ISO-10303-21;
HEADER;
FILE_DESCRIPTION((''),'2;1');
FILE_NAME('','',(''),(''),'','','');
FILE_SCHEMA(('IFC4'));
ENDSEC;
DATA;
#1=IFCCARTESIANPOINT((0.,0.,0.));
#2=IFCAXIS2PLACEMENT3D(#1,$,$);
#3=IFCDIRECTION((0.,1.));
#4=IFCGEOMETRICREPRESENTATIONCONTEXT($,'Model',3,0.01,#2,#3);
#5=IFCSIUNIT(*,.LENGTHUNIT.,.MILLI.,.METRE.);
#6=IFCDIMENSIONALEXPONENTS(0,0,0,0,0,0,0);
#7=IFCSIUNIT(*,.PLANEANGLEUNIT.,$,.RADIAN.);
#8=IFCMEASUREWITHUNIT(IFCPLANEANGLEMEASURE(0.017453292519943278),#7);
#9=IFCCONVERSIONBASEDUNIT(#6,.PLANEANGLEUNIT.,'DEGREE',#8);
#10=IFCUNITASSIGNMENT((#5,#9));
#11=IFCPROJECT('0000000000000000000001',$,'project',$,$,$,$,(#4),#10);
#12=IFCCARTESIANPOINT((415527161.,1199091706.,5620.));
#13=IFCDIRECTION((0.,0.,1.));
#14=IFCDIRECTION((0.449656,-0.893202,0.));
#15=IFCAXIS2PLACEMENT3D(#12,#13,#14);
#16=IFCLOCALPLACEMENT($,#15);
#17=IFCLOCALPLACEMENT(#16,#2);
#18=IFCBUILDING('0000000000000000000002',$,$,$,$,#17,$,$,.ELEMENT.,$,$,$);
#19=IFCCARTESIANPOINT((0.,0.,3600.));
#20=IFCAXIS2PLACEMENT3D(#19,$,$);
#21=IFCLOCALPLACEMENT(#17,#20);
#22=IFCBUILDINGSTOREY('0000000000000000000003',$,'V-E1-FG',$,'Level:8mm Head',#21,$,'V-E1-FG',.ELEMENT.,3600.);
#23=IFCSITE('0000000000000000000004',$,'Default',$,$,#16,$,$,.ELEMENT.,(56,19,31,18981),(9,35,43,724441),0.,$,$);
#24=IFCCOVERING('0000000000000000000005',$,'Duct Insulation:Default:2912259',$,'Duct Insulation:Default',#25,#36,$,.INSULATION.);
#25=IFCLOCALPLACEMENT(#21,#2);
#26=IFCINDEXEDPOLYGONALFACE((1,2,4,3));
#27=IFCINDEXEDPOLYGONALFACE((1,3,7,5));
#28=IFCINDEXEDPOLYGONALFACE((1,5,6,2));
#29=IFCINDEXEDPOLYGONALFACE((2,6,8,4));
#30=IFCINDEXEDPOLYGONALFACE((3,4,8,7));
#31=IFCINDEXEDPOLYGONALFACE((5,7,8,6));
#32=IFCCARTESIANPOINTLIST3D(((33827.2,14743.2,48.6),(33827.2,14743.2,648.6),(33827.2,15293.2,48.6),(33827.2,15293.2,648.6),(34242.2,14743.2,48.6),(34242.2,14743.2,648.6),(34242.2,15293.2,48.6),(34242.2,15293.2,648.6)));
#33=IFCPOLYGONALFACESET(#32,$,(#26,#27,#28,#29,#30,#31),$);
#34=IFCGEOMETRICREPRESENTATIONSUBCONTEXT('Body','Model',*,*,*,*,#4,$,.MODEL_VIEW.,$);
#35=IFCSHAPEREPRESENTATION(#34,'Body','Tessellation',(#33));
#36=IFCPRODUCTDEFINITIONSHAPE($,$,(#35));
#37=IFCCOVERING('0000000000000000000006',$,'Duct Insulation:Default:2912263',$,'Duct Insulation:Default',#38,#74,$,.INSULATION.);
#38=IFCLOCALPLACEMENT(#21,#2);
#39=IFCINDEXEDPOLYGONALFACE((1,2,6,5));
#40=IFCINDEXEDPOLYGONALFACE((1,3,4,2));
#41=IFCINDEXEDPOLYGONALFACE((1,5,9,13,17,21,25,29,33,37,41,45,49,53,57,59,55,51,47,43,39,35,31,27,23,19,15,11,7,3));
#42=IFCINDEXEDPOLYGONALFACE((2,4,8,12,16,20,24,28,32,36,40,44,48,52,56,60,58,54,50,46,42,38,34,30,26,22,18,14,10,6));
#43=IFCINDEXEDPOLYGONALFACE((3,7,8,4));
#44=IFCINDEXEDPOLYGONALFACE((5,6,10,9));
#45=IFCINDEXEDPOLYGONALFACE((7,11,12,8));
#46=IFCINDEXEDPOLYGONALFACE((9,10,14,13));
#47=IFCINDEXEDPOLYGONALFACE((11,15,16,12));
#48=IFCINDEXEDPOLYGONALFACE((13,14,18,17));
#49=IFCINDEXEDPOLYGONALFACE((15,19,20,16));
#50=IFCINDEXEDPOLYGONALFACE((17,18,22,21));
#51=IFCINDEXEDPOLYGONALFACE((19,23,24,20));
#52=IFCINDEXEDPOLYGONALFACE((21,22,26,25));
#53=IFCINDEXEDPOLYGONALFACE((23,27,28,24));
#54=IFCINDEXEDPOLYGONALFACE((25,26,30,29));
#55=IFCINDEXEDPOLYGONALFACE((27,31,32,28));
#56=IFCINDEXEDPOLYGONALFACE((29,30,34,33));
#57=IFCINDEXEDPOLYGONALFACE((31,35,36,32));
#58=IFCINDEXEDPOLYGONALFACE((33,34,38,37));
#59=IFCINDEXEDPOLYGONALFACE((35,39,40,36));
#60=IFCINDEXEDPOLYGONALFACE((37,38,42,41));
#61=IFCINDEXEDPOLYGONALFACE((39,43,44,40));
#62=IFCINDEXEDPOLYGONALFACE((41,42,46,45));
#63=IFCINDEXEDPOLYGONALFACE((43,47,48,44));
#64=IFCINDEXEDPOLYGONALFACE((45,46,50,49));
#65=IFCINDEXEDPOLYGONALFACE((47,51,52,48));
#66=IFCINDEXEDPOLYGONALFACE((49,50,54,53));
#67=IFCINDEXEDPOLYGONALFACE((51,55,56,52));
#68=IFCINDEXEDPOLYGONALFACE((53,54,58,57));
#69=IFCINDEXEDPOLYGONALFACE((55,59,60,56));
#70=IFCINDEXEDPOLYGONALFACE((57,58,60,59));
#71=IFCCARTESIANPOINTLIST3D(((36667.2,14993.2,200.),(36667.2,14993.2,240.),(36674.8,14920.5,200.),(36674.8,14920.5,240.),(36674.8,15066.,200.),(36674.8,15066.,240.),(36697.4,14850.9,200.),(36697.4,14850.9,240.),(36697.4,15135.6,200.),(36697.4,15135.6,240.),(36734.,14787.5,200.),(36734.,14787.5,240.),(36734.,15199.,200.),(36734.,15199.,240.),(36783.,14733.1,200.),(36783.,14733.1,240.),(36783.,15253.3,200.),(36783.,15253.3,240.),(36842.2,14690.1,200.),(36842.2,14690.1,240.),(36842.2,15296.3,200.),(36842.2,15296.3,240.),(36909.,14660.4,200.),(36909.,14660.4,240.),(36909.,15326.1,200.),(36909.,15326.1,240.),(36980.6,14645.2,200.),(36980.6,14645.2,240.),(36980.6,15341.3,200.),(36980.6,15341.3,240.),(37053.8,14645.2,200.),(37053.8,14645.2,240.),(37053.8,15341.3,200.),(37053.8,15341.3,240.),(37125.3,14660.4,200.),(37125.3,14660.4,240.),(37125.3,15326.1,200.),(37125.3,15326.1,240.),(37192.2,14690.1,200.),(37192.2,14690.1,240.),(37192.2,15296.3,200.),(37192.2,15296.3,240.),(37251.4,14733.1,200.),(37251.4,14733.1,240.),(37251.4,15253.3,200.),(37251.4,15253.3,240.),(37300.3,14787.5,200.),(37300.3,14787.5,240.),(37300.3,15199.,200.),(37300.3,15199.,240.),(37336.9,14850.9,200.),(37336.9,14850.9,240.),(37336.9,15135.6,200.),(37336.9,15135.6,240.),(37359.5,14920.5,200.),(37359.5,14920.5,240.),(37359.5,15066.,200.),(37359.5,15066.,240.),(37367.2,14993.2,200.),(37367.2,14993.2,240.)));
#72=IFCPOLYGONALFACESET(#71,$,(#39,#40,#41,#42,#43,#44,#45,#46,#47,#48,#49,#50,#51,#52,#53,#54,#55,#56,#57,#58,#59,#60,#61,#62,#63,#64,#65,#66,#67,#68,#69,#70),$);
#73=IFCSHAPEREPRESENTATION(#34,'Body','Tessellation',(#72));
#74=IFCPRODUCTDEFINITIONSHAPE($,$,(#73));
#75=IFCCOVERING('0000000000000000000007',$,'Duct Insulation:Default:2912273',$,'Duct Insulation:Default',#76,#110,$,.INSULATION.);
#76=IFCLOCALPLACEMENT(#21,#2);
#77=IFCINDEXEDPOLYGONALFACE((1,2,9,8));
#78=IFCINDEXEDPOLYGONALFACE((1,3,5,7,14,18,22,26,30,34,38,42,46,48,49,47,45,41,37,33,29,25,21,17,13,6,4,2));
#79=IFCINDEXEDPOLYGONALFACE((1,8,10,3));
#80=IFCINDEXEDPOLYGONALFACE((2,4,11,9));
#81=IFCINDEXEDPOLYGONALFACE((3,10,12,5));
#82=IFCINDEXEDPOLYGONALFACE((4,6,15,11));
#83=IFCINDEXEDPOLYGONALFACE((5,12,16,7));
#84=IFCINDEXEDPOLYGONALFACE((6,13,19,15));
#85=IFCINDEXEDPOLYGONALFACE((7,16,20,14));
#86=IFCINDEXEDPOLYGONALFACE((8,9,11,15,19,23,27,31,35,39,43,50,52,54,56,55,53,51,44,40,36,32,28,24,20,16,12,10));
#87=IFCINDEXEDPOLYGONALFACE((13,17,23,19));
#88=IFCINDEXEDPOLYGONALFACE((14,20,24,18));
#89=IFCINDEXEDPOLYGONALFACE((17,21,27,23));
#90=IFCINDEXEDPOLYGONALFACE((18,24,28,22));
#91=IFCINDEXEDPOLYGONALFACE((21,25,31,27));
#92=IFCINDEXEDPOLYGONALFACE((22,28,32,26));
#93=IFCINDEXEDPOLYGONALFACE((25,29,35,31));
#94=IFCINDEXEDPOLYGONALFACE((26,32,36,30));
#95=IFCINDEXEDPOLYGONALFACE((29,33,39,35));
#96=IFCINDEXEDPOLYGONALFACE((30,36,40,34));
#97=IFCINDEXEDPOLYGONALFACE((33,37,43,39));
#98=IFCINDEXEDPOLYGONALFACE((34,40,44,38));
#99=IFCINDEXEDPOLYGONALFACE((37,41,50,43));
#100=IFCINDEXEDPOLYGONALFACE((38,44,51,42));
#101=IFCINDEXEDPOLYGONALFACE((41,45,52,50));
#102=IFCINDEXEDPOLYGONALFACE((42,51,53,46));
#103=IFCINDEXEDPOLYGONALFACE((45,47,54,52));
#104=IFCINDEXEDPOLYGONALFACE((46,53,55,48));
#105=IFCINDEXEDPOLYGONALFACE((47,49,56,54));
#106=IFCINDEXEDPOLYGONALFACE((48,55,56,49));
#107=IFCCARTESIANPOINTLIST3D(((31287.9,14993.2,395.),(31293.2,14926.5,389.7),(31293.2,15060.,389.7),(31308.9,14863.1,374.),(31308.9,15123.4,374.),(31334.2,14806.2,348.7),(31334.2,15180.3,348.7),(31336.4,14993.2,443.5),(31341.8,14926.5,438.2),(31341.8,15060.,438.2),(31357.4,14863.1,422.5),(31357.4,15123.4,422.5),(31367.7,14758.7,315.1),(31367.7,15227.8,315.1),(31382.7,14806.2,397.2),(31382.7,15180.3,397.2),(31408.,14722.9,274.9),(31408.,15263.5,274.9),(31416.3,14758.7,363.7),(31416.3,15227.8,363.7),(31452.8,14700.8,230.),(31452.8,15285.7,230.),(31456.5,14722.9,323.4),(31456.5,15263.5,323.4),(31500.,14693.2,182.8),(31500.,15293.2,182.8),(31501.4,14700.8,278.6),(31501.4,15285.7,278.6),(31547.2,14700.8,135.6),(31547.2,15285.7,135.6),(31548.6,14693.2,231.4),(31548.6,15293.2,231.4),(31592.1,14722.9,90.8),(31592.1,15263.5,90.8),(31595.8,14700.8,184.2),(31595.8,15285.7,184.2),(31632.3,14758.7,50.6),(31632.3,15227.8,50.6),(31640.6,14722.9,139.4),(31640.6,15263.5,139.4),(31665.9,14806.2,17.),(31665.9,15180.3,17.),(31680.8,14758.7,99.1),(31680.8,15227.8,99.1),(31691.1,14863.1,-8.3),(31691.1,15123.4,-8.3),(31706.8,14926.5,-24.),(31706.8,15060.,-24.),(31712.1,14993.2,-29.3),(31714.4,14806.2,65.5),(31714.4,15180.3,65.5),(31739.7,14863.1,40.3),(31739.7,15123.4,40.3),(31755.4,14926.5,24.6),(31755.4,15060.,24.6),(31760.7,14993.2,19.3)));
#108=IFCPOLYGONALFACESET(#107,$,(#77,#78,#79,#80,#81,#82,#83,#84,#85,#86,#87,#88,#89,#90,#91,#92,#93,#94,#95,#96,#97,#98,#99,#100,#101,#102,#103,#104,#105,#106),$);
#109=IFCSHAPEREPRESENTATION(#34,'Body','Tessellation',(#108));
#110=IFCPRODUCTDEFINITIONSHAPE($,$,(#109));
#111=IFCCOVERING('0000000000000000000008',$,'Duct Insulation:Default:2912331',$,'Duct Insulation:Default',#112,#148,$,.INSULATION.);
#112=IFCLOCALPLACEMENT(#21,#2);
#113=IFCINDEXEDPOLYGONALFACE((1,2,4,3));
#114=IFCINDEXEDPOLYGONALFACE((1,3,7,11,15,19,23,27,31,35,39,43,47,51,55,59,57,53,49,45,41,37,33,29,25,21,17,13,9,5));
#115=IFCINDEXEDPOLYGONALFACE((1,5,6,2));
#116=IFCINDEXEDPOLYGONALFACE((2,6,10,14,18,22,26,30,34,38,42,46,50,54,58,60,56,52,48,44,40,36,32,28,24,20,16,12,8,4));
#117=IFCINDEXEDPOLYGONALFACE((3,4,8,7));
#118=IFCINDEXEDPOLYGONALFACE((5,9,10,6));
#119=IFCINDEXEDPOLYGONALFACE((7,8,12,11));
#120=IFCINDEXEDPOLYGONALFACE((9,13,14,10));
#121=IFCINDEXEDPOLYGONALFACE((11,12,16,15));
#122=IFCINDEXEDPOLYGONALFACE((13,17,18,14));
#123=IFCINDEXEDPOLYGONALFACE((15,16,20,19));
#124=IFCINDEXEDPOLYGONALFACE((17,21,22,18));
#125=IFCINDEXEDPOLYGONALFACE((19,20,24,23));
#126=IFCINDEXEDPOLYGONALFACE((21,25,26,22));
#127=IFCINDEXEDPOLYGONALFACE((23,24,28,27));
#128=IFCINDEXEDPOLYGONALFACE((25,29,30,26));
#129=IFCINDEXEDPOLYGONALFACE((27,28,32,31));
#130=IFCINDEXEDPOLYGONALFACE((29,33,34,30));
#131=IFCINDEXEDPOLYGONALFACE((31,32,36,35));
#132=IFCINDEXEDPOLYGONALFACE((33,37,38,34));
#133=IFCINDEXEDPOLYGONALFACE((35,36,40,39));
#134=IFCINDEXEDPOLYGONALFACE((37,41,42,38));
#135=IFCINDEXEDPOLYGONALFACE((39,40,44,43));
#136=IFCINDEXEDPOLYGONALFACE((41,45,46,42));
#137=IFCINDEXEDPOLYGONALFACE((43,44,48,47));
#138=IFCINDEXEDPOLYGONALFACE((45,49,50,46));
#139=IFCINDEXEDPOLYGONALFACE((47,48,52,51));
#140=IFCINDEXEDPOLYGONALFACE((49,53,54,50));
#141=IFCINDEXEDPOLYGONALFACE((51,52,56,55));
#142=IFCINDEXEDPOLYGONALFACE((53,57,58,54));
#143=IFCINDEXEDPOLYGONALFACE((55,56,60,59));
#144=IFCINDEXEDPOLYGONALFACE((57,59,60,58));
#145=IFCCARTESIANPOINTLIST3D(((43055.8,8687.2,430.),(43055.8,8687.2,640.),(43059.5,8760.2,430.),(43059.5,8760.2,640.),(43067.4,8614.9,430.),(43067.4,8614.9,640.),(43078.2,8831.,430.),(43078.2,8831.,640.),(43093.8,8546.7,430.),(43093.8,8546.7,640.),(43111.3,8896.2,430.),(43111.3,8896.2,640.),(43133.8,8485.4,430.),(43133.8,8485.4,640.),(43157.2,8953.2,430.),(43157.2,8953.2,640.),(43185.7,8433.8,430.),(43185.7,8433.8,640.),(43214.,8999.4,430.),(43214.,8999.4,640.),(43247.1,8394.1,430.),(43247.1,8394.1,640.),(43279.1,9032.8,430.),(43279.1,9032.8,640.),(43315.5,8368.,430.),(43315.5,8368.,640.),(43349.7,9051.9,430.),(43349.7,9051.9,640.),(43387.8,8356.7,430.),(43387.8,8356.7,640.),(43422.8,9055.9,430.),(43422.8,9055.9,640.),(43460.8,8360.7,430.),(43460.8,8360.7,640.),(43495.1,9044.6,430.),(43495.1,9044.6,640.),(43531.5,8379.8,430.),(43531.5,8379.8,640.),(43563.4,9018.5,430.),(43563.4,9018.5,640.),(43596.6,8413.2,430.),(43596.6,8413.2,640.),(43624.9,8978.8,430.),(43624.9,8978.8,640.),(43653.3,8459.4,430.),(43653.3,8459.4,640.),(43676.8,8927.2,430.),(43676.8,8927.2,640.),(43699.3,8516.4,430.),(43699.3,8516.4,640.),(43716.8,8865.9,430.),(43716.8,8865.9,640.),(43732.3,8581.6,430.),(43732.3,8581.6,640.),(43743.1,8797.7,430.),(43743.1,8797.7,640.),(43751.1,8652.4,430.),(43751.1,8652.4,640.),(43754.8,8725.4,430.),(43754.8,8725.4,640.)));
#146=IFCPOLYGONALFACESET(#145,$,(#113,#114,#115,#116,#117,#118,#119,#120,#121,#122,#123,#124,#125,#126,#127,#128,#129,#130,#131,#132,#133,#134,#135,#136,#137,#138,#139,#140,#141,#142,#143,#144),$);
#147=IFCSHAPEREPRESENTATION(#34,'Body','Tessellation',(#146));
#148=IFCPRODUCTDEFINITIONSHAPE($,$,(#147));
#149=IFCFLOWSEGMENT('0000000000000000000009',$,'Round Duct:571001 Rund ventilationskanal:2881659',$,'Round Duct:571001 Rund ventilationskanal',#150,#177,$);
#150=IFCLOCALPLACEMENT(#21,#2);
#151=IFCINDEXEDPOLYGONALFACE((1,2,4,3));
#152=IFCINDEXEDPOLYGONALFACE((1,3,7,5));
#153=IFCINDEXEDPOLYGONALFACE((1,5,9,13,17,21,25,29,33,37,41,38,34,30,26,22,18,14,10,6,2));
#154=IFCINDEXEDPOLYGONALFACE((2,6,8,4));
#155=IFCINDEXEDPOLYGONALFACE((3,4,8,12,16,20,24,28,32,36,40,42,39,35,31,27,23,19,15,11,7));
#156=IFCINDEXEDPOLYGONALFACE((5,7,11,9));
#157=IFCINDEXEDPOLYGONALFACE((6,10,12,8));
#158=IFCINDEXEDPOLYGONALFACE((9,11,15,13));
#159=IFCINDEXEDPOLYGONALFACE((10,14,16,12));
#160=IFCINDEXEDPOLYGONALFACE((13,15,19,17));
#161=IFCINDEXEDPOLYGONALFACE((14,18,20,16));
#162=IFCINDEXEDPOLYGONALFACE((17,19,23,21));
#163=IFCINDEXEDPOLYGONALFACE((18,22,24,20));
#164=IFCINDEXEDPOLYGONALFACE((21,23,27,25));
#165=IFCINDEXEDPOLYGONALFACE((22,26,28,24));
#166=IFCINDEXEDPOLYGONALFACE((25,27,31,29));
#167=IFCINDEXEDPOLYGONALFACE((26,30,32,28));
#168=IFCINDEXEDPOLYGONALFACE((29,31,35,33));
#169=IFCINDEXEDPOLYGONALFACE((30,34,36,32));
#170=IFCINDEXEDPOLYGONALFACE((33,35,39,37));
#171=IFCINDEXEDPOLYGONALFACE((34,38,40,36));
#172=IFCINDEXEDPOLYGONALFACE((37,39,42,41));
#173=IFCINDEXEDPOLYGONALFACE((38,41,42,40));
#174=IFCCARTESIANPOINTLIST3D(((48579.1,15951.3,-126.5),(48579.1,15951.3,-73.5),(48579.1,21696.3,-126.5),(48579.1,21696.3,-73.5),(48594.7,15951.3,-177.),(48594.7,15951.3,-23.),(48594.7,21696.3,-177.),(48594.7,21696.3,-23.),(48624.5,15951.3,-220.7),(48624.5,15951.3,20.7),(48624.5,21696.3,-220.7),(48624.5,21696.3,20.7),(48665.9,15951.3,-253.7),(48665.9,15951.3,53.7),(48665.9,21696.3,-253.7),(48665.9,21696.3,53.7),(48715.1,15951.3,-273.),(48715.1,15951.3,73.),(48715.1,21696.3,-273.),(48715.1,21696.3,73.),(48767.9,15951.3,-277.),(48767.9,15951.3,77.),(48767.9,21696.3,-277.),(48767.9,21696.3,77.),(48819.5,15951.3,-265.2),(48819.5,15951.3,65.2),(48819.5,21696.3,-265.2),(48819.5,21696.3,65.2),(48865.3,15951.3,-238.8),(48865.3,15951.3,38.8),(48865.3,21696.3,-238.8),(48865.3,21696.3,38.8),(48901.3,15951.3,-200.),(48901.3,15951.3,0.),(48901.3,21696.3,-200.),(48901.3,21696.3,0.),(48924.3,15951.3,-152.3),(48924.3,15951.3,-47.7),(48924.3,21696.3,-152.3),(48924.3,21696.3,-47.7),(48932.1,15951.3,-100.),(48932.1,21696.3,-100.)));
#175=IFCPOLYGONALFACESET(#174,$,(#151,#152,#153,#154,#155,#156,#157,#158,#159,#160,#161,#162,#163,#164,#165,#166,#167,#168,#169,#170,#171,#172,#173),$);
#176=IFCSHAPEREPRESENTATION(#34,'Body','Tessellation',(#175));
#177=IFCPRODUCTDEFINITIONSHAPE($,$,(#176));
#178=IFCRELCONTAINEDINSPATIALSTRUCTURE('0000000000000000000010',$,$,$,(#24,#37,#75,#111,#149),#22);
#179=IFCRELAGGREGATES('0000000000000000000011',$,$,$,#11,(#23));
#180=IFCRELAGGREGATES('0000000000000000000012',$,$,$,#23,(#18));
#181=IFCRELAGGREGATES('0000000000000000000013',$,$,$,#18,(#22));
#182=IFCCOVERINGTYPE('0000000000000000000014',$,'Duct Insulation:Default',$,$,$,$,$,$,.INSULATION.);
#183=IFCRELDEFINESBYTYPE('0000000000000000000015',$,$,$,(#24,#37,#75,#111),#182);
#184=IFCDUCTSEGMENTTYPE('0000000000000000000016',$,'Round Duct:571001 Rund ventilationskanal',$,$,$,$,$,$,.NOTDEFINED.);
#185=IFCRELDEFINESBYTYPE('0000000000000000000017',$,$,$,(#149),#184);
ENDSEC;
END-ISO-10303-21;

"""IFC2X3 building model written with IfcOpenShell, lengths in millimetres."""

from ifc_helpers import new_model, entity, si_unit, converted_unit, direction, frame, frame_2d, origin, place, context, subcontext, project, spatial, rectangle, circle, extrude, type_object, element, save


model = new_model("IFC2X3")

# Units and contexts
model_context = context("Model", 3, precision=0.01, world=origin(), true_north=direction((0.0, 1.0)))
body_context = subcontext(model_context, "Body", "Model", "MODEL_VIEW")
ifc_project = project(units=[si_unit("LENGTHUNIT", "METRE", prefix="MILLI"), converted_unit("PLANEANGLEUNIT", "DEGREE", entity("IfcPlaneAngleMeasure", 0.017453292519943278), si_unit("PLANEANGLEUNIT", "RADIAN"), dimensions=[0, 0, 0, 0, 0, 0, 0])], contexts=[model_context])

# Site, building, storey
site_placement = place(None, frame((415527161.0, 1199091706.0, 5620.0), z_axis=(0.0, 0.0, 1.0), x_axis=(0.449656, -0.893202, 0.0)))
site = spatial("IfcSite", under=ifc_project, at=site_placement, Name="Default", CompositionType="ELEMENT", RefLatitude=(56, 19, 31, 18981), RefLongitude=(9, 35, 43, 724441), RefElevation=0.0)
building_placement = place(site_placement, origin())
building = spatial("IfcBuilding", under=site, at=building_placement, CompositionType="ELEMENT")
storey_placement = place(building_placement, frame((0.0, 0.0, 3600.0)))
storey = spatial("IfcBuildingStorey", under=building, at=storey_placement, Name="V-E1-FG", ObjectType="Level:8mm Head", LongName="V-E1-FG", CompositionType="ELEMENT", Elevation=3600.0)

# Coverings
covering_type = type_object("IfcCoveringType", Name="Duct Insulation:Default", PredefinedType="INSULATION")
covering_1_placement = place(storey_placement, origin())
element("IfcCovering", 1, at=covering_1_placement, inside=storey, type_object=covering_type, Name="Duct Insulation:Default:2912259", ObjectType="Duct Insulation:Default", PredefinedType="INSULATION", context=body_context, shape_type="SweptSolid", body=[
    extrude(rectangle(XDim=415.0, YDim=550.0, at=frame_2d((0.0, 0.0), x_axis=(1.0, 0.0))), frame((34034.7, 15018.2, 48.6)), (0.0, 0.0, 1.0), 600.0),
])
covering_2_placement = place(storey_placement, origin())
element("IfcCovering", 2, at=covering_2_placement, inside=storey, type_object=covering_type, Name="Duct Insulation:Default:2912263", ObjectType="Duct Insulation:Default", PredefinedType="INSULATION", context=body_context, shape_type="SweptSolid", body=[
    extrude(circle(Radius=350.0, at=frame_2d((0.0, 0.0), x_axis=(1.0, 0.0))), frame((37017.2, 14993.2, 200.0), z_axis=(0.0, 0.0, 1.0), x_axis=(-1.0, 0.0, 0.0)), (0.0, 0.0, 1.0), 40.0),
])
covering_3_placement = place(storey_placement, origin())
element("IfcCovering", 3, at=covering_3_placement, inside=storey, type_object=covering_type, Name="Duct Insulation:Default:2912273", ObjectType="Duct Insulation:Default", PredefinedType="INSULATION", context=body_context, shape_type="SweptSolid", body=[
    extrude(circle(Radius=300.0, at=frame_2d((0.0, 0.0), x_axis=(1.0, 0.0))), frame((31500.0, 14993.2, 182.8), z_axis=(0.707107, 0.0, 0.707107), x_axis=(0.0, 1.0, 0.0)), (0.0, 0.0, 1.0), 68.7),
])
covering_4_placement = place(storey_placement, origin())
element("IfcCovering", 4, at=covering_4_placement, inside=storey, type_object=covering_type, Name="Duct Insulation:Default:2912331", ObjectType="Duct Insulation:Default", PredefinedType="INSULATION", context=body_context, shape_type="SweptSolid", body=[
    extrude(circle(Radius=350.0, at=frame_2d((0.0, 0.0), x_axis=(1.0, 0.0))), frame((43405.3, 8706.3, 430.0), z_axis=(0.0, 0.0, 1.0), x_axis=(0.04999, 0.99875, 0.0)), (0.0, 0.0, 1.0), 210.0),
])

# Flow segment
duct_segment_type = type_object("IfcDuctSegmentType", Name="Round Duct:571001 Rund ventilationskanal", PredefinedType="NOTDEFINED")
flow_segment_1_placement = place(storey_placement, origin())
element("IfcFlowSegment", 5, at=flow_segment_1_placement, inside=storey, type_object=duct_segment_type, Name="Round Duct:571001 Rund ventilationskanal:2881659", ObjectType="Round Duct:571001 Rund ventilationskanal", context=body_context, shape_type="SweptSolid", body=[
    extrude(circle(Radius=177.5, at=frame_2d((0.0, 0.0), x_axis=(1.0, 0.0))), frame((48754.6, 15951.3, -100.0), z_axis=(0.0, 1.0, 0.0), x_axis=(1.0, 0.0, 0.0)), (0.0, 0.0, 1.0), 5745.0),
])

save(model, "model.ifc")
